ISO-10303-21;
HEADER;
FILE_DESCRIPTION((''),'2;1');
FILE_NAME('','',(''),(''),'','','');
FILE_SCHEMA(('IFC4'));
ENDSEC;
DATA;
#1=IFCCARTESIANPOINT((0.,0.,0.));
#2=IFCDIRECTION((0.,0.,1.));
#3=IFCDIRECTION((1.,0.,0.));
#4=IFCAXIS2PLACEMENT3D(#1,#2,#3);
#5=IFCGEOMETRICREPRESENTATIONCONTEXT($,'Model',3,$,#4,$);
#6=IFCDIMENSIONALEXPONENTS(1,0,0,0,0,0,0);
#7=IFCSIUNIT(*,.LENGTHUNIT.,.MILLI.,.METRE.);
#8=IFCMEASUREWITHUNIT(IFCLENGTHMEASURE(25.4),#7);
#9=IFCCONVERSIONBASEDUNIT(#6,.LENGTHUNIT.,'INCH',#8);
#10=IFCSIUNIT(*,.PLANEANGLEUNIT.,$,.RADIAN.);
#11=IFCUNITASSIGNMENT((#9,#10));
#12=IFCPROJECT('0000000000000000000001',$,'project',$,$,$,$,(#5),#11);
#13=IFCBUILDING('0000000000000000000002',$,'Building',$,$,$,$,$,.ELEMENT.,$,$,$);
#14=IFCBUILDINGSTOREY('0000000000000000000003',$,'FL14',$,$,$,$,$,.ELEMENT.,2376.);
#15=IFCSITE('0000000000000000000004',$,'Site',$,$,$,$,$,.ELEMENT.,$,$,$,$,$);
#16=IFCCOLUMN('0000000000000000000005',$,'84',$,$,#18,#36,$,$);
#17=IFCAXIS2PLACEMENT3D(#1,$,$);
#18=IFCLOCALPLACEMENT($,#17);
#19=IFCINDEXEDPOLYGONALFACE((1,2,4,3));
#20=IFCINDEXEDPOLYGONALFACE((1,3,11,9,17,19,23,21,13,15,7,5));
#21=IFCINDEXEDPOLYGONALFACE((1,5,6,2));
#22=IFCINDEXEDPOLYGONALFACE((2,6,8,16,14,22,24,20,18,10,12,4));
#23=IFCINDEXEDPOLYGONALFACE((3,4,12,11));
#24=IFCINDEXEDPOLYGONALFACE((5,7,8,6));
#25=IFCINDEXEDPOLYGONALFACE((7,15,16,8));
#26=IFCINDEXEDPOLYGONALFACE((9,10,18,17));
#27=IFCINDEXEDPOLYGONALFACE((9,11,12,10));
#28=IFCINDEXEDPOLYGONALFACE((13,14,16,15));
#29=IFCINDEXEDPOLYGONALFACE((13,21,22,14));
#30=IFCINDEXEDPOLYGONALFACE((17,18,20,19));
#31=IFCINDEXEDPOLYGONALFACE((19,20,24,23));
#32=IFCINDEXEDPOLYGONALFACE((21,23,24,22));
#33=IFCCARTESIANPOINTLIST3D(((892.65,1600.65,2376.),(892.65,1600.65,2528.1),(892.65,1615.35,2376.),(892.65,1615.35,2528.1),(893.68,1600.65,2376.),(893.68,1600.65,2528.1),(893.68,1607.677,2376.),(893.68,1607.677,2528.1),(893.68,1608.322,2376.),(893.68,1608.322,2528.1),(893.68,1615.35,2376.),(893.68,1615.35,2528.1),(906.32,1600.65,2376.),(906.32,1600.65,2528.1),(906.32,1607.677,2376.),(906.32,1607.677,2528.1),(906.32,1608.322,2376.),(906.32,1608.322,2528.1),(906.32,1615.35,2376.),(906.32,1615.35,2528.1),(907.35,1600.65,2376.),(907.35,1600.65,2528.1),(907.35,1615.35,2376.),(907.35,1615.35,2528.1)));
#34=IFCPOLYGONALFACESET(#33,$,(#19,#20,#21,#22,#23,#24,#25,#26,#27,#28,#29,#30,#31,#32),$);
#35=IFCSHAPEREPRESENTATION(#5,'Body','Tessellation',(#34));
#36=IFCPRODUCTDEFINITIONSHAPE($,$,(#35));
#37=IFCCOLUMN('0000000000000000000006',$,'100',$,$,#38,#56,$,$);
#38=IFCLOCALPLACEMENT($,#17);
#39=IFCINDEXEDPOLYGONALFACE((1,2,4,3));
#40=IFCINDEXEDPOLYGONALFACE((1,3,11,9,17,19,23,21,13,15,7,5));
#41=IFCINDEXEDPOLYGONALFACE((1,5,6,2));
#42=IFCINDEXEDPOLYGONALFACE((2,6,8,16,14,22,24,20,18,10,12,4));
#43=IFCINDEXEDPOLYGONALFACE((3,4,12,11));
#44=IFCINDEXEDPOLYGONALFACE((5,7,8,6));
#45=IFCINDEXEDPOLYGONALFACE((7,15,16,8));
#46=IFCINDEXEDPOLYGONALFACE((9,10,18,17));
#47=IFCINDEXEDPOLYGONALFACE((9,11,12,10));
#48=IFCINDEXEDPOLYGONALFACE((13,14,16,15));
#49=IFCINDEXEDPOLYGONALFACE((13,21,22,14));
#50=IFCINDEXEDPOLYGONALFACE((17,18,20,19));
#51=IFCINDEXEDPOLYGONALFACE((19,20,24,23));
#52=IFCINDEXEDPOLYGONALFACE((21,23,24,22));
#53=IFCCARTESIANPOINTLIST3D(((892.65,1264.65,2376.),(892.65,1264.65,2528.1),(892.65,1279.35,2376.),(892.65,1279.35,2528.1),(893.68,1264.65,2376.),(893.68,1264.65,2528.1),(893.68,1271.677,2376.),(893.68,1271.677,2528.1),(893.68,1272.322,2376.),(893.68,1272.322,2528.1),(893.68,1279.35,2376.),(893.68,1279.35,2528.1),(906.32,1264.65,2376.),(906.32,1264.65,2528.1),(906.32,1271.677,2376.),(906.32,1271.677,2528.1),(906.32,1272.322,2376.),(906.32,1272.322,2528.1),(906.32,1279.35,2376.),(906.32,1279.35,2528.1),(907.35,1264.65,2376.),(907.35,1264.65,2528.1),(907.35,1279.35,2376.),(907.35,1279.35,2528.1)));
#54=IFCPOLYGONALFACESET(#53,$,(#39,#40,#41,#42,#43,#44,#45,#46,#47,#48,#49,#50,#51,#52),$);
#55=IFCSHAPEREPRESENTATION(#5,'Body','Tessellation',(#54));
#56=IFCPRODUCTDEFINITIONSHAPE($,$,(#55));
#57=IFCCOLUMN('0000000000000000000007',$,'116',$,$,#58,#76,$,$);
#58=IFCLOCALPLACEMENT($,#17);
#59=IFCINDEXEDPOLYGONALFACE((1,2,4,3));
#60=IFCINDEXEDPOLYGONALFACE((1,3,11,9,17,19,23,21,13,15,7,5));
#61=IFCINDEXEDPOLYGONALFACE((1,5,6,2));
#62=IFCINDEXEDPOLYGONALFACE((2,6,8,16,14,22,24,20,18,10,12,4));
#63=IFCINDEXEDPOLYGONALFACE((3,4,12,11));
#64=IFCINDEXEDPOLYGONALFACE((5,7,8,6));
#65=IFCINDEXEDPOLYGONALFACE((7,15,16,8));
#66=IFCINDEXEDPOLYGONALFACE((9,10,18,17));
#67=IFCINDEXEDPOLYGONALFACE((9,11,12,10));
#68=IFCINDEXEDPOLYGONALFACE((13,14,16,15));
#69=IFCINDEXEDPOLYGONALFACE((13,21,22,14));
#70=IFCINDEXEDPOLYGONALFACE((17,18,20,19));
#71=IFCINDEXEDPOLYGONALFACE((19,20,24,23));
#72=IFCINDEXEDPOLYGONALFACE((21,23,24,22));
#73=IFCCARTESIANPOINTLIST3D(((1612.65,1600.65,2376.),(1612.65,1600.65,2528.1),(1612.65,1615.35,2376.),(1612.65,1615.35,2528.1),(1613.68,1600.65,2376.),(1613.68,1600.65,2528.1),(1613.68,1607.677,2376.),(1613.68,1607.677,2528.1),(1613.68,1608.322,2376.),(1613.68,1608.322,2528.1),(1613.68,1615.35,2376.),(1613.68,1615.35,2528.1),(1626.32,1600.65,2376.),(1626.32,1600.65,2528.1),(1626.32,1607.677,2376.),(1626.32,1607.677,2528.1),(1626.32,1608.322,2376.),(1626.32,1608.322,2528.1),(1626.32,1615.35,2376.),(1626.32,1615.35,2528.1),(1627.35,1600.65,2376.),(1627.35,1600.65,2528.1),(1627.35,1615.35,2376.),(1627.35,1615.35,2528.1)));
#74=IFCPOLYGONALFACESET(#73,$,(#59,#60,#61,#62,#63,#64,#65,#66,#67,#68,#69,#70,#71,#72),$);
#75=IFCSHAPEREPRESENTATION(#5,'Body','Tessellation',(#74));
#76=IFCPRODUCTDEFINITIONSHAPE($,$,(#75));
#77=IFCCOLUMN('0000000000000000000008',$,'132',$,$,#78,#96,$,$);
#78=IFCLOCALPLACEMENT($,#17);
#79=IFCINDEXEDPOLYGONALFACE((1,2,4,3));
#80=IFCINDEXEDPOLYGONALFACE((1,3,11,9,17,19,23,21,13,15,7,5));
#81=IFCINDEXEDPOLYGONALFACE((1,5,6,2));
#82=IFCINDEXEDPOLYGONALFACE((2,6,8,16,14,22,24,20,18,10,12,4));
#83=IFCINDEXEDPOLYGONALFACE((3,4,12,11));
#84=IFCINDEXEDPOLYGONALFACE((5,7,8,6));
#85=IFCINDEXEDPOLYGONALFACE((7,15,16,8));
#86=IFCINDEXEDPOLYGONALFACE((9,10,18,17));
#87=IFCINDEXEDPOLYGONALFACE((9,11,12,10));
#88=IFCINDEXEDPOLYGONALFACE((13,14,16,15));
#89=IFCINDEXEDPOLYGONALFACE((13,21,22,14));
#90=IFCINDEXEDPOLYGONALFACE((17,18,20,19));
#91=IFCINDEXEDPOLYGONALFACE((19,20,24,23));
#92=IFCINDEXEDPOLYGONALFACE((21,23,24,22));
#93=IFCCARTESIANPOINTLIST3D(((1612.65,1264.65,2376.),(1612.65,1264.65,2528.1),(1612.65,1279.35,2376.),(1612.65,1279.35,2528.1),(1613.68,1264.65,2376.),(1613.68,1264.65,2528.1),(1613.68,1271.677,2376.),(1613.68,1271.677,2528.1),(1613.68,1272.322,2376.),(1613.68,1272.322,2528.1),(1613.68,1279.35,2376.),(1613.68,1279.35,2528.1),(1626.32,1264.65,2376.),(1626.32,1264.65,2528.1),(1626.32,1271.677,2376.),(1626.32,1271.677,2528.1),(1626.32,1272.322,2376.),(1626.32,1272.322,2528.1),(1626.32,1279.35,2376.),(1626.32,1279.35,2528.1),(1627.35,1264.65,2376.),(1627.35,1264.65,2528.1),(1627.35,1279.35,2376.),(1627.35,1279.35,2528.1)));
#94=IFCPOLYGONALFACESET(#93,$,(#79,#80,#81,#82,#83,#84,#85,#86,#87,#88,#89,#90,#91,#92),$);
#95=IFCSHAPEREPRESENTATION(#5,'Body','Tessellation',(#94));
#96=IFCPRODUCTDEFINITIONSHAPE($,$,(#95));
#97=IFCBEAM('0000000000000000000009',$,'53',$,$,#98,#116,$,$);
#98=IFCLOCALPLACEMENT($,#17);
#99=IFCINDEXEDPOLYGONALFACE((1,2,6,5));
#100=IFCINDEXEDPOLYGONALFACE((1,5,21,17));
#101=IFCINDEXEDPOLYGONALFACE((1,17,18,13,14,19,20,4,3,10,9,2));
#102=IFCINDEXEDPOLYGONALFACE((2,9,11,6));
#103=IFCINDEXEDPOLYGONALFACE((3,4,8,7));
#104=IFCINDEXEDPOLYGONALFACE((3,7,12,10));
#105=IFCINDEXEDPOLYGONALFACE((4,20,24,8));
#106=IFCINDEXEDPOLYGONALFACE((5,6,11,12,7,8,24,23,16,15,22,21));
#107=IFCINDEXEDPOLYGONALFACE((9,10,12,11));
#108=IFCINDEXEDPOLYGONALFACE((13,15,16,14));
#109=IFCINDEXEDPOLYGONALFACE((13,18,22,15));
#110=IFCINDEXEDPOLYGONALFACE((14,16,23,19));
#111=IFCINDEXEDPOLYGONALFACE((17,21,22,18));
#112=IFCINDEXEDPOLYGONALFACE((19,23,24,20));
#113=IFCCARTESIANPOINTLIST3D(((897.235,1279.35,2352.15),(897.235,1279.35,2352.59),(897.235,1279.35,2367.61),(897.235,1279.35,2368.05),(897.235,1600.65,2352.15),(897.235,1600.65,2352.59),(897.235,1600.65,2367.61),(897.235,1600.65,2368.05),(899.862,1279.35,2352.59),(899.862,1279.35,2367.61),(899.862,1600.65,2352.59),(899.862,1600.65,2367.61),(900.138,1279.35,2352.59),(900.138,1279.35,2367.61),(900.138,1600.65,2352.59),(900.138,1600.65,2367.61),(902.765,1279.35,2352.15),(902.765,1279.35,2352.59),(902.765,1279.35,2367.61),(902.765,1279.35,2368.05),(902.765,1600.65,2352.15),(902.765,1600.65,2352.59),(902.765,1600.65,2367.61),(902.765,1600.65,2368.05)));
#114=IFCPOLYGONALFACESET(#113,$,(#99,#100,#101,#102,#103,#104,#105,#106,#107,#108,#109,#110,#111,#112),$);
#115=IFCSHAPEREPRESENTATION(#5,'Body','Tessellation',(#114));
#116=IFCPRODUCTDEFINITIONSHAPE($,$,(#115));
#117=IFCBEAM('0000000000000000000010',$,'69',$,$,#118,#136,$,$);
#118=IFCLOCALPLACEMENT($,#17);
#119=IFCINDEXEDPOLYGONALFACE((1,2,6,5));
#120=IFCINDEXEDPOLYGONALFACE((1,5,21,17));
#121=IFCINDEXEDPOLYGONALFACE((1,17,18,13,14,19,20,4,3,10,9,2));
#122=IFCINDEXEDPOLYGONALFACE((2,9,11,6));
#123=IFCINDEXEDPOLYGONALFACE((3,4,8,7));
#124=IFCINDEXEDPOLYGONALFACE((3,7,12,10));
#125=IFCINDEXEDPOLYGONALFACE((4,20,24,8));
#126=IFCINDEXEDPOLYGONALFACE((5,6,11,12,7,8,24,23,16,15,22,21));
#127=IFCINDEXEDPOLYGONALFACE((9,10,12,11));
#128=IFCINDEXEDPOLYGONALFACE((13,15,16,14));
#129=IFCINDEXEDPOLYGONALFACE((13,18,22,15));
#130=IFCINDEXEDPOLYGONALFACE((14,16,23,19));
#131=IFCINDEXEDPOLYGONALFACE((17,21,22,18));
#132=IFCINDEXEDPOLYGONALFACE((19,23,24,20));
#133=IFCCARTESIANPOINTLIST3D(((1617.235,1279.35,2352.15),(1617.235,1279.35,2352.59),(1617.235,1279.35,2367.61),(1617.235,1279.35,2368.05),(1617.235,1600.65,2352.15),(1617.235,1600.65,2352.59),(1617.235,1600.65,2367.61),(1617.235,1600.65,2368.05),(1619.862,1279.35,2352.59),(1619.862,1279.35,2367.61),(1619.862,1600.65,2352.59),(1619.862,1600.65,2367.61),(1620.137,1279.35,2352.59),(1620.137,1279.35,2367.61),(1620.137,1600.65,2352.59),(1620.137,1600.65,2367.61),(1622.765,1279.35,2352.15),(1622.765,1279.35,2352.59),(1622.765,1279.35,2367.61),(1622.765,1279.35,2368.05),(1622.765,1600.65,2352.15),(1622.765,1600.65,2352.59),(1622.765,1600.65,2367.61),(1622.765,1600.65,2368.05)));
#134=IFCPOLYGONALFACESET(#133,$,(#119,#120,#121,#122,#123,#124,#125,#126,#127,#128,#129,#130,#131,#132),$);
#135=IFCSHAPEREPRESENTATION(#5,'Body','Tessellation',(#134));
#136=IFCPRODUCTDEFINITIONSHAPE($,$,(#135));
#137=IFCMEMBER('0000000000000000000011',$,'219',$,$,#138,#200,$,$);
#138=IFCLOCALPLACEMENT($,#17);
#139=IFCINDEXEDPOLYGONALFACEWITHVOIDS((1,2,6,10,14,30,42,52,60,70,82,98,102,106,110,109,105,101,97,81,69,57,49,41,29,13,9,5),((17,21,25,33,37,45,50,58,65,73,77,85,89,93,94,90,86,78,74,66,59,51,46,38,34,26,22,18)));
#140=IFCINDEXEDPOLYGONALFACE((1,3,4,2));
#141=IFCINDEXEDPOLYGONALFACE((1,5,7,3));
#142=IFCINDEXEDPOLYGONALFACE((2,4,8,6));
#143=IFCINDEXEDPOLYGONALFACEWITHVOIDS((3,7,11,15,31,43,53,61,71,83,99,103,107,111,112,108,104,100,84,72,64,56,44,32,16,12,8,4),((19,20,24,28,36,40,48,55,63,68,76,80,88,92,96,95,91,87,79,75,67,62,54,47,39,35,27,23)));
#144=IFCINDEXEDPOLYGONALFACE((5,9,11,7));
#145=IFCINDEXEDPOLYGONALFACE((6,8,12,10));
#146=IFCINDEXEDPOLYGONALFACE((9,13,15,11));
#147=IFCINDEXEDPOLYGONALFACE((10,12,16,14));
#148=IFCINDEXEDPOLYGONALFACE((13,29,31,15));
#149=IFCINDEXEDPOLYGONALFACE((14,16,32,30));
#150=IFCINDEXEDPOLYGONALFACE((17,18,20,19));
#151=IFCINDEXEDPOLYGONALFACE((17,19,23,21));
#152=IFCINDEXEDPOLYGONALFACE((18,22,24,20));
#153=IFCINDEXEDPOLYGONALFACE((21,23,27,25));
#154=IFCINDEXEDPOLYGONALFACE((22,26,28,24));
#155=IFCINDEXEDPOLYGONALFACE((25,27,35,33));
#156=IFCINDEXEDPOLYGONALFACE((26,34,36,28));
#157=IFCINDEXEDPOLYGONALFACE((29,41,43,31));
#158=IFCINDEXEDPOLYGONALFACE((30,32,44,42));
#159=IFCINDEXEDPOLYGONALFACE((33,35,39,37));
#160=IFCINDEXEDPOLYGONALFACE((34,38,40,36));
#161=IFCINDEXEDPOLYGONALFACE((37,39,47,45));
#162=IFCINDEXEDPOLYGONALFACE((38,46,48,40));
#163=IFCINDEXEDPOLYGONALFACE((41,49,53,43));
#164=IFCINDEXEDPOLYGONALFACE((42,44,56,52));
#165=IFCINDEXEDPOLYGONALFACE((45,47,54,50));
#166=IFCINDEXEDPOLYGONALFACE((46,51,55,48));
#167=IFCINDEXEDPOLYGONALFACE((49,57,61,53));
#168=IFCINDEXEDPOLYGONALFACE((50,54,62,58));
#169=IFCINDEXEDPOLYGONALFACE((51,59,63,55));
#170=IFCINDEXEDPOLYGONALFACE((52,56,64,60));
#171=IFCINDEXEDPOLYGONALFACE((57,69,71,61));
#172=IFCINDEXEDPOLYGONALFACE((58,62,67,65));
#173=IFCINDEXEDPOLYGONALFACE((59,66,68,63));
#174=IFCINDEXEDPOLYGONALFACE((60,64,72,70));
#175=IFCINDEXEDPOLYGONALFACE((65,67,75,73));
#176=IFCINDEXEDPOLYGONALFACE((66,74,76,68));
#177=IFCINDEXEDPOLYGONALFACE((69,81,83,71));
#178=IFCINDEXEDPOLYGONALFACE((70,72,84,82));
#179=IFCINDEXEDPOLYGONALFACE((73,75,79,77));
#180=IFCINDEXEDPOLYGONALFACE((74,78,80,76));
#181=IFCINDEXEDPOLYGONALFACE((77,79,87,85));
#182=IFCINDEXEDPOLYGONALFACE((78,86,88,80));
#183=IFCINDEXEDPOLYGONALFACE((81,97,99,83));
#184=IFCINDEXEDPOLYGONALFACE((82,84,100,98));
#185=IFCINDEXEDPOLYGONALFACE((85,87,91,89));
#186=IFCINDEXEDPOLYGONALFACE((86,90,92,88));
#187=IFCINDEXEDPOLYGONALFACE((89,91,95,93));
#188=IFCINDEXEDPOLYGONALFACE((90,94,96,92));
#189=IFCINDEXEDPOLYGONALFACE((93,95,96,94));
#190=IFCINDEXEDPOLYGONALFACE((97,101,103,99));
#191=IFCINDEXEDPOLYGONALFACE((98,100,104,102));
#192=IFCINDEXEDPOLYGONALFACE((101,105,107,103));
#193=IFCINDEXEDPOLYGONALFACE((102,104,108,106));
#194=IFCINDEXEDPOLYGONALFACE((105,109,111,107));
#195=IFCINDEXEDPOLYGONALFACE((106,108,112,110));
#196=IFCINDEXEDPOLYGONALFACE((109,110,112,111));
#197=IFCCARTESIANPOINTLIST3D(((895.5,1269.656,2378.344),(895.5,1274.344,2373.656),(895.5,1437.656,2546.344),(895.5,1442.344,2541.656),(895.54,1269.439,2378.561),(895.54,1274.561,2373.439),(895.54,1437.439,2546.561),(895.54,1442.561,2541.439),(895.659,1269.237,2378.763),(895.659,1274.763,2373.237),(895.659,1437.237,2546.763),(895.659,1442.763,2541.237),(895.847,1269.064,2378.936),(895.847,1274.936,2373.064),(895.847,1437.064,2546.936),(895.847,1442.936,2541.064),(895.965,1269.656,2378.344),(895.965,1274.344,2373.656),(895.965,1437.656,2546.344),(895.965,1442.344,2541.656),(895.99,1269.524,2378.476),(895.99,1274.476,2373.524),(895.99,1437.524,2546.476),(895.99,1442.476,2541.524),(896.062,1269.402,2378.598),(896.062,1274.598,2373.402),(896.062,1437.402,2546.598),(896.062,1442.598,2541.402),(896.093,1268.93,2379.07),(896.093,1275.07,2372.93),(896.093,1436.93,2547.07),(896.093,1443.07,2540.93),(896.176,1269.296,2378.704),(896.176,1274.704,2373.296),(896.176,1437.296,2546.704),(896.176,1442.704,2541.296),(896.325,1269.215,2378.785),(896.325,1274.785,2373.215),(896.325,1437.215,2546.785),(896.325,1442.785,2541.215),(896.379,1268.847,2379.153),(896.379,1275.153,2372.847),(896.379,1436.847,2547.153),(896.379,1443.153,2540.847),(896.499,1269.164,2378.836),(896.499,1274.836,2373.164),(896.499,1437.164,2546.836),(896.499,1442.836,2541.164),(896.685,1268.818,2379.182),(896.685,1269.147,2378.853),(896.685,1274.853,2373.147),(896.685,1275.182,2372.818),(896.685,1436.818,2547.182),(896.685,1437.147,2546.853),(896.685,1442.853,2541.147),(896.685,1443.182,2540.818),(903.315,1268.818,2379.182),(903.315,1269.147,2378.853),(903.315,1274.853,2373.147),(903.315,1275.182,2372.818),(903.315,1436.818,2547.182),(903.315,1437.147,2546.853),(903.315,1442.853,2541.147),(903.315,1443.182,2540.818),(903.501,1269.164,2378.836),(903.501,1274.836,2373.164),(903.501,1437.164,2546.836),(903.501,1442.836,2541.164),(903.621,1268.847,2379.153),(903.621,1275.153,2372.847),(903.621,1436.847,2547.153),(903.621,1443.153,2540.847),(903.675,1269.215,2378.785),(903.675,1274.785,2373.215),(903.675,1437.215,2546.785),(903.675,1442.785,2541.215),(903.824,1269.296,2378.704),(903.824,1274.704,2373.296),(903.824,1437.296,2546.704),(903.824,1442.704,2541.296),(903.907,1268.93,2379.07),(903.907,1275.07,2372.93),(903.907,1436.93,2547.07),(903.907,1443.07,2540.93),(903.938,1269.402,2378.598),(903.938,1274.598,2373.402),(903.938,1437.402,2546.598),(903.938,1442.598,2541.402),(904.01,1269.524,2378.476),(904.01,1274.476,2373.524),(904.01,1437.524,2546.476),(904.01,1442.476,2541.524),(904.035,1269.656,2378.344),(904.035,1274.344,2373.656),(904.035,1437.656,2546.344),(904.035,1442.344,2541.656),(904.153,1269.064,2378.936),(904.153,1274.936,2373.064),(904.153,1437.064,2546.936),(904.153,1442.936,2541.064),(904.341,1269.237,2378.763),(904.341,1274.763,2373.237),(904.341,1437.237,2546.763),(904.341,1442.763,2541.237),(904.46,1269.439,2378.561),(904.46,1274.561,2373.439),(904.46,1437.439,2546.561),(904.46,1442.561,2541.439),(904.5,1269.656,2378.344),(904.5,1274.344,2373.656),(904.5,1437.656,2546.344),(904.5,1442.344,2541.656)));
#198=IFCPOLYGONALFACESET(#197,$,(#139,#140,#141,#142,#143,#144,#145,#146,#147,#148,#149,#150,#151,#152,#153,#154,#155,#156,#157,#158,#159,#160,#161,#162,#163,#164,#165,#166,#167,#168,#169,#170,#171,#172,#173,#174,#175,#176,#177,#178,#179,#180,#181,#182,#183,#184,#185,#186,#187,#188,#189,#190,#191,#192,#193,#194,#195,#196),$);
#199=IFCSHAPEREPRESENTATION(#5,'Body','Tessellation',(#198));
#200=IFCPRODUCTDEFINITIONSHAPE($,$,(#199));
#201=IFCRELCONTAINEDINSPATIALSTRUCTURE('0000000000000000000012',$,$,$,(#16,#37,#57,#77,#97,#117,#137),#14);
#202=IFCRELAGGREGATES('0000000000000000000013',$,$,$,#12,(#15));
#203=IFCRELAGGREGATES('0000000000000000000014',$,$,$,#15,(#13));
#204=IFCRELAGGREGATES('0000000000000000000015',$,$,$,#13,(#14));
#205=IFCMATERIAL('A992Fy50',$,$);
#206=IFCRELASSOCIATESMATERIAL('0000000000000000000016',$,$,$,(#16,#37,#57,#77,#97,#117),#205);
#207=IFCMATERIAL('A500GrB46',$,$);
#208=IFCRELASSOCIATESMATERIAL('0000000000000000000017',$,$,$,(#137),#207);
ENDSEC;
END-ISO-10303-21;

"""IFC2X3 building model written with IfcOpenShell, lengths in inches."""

from ifc_helpers import new_model, entity, si_unit, converted_unit, frame, origin_with_axes, origin_2d_with_axis, place, context, project, spatial, hollow_rectangle, i_section, transform_2d, derived_profile, extrude, material, element, save


model = new_model("IFC2X3")

# Units and contexts
model_context = context("Model", 3, world=origin_with_axes())
ifc_project = project(units=[converted_unit("LENGTHUNIT", "INCH", entity("IfcLengthMeasure", 25.4), si_unit("LENGTHUNIT", "METRE", prefix="MILLI"), dimensions=[1, 0, 0, 0, 0, 0, 0]), si_unit("PLANEANGLEUNIT", "RADIAN")], contexts=[model_context])

# Site, building, storey
site = spatial("IfcSite", under=ifc_project, Name="Site", CompositionType="ELEMENT")
building = spatial("IfcBuilding", under=site, Name="Building", CompositionType="ELEMENT")
storey = spatial("IfcBuildingStorey", under=building, Name="FL14", CompositionType="ELEMENT", Elevation=2376.0)

# Columns
ifc_material_1 = material(Name="A992Fy50")
for number, where, z_axis, x_axis, name in (
    (1, (900.0, 1608.0, 2376.0), (0.0, 0.0, 1.0), (0.0, -1.0, 0.0), "84"),
    (2, (900.0, 1272.0, 2376.0), (0.0, 0.0, 1.0), (0.0, -1.0, 0.0), "100"),
    (3, (1620.0, 1608.0, 2376.0), (0.0, 0.0, 1.0), (0.0, -1.0, 0.0), "116"),
    (4, (1620.0, 1272.0, 2376.0), (0.0, 0.0, 1.0), (0.0, -1.0, 0.0), "132"),
):
    element("IfcColumn", number, at=place(None, frame(where, z_axis=z_axis, x_axis=x_axis)), inside=storey, material=ifc_material_1, Name=name, context=model_context, shape_type="SweptSolid", body=[
        extrude(i_section(OverallWidth=14.7, OverallDepth=14.7, WebThickness=0.645, FlangeThickness=1.03, at=origin_2d_with_axis()), origin_with_axes(), (0.0, 0.0, 1.0), 152.1),
    ])

# Beams
for number, where, z_axis, x_axis, name in (
    (5, (900.0, 1279.35, 2376.0), (0.0, 1.0, 0.0), (-1.0, 0.0, 0.0), "53"),
    (6, (1620.0, 1279.35, 2376.0), (0.0, 1.0, 0.0), (-1.0, 0.0, 0.0), "69"),
):
    element("IfcBeam", number, at=place(None, frame(where, z_axis=z_axis, x_axis=x_axis)), inside=storey, material=ifc_material_1, Name=name, context=model_context, shape_type="SweptSolid", body=[
        extrude(derived_profile(i_section(OverallWidth=5.53, OverallDepth=15.9, WebThickness=0.275, FlangeThickness=0.44, at=origin_2d_with_axis()), transform_2d((0.0, -7.95))), origin_with_axes(), (0.0, 0.0, 1.0), 321.3),
    ])

# Member
ifc_material_2 = material(Name="A500GrB46")
for number, where, z_axis, x_axis, name in (
    (7, (900.0, 1272.0, 2376.0), (0.0, 0.707107, 0.707107), (-1.0, 0.0, 0.0), "219"),
):
    element("IfcMember", number, at=place(None, frame(where, z_axis=z_axis, x_axis=x_axis)), inside=storey, material=ifc_material_2, Name=name, context=model_context, shape_type="SweptSolid", body=[
        extrude(hollow_rectangle(XDim=9.0, YDim=9.0, WallThickness=0.465, InnerFilletRadius=0.72, OuterFilletRadius=1.185, at=origin_2d_with_axis()), origin_with_axes(), (0.0, 0.0, 1.0), 237.588),
    ])

save(model, "model.ifc")
